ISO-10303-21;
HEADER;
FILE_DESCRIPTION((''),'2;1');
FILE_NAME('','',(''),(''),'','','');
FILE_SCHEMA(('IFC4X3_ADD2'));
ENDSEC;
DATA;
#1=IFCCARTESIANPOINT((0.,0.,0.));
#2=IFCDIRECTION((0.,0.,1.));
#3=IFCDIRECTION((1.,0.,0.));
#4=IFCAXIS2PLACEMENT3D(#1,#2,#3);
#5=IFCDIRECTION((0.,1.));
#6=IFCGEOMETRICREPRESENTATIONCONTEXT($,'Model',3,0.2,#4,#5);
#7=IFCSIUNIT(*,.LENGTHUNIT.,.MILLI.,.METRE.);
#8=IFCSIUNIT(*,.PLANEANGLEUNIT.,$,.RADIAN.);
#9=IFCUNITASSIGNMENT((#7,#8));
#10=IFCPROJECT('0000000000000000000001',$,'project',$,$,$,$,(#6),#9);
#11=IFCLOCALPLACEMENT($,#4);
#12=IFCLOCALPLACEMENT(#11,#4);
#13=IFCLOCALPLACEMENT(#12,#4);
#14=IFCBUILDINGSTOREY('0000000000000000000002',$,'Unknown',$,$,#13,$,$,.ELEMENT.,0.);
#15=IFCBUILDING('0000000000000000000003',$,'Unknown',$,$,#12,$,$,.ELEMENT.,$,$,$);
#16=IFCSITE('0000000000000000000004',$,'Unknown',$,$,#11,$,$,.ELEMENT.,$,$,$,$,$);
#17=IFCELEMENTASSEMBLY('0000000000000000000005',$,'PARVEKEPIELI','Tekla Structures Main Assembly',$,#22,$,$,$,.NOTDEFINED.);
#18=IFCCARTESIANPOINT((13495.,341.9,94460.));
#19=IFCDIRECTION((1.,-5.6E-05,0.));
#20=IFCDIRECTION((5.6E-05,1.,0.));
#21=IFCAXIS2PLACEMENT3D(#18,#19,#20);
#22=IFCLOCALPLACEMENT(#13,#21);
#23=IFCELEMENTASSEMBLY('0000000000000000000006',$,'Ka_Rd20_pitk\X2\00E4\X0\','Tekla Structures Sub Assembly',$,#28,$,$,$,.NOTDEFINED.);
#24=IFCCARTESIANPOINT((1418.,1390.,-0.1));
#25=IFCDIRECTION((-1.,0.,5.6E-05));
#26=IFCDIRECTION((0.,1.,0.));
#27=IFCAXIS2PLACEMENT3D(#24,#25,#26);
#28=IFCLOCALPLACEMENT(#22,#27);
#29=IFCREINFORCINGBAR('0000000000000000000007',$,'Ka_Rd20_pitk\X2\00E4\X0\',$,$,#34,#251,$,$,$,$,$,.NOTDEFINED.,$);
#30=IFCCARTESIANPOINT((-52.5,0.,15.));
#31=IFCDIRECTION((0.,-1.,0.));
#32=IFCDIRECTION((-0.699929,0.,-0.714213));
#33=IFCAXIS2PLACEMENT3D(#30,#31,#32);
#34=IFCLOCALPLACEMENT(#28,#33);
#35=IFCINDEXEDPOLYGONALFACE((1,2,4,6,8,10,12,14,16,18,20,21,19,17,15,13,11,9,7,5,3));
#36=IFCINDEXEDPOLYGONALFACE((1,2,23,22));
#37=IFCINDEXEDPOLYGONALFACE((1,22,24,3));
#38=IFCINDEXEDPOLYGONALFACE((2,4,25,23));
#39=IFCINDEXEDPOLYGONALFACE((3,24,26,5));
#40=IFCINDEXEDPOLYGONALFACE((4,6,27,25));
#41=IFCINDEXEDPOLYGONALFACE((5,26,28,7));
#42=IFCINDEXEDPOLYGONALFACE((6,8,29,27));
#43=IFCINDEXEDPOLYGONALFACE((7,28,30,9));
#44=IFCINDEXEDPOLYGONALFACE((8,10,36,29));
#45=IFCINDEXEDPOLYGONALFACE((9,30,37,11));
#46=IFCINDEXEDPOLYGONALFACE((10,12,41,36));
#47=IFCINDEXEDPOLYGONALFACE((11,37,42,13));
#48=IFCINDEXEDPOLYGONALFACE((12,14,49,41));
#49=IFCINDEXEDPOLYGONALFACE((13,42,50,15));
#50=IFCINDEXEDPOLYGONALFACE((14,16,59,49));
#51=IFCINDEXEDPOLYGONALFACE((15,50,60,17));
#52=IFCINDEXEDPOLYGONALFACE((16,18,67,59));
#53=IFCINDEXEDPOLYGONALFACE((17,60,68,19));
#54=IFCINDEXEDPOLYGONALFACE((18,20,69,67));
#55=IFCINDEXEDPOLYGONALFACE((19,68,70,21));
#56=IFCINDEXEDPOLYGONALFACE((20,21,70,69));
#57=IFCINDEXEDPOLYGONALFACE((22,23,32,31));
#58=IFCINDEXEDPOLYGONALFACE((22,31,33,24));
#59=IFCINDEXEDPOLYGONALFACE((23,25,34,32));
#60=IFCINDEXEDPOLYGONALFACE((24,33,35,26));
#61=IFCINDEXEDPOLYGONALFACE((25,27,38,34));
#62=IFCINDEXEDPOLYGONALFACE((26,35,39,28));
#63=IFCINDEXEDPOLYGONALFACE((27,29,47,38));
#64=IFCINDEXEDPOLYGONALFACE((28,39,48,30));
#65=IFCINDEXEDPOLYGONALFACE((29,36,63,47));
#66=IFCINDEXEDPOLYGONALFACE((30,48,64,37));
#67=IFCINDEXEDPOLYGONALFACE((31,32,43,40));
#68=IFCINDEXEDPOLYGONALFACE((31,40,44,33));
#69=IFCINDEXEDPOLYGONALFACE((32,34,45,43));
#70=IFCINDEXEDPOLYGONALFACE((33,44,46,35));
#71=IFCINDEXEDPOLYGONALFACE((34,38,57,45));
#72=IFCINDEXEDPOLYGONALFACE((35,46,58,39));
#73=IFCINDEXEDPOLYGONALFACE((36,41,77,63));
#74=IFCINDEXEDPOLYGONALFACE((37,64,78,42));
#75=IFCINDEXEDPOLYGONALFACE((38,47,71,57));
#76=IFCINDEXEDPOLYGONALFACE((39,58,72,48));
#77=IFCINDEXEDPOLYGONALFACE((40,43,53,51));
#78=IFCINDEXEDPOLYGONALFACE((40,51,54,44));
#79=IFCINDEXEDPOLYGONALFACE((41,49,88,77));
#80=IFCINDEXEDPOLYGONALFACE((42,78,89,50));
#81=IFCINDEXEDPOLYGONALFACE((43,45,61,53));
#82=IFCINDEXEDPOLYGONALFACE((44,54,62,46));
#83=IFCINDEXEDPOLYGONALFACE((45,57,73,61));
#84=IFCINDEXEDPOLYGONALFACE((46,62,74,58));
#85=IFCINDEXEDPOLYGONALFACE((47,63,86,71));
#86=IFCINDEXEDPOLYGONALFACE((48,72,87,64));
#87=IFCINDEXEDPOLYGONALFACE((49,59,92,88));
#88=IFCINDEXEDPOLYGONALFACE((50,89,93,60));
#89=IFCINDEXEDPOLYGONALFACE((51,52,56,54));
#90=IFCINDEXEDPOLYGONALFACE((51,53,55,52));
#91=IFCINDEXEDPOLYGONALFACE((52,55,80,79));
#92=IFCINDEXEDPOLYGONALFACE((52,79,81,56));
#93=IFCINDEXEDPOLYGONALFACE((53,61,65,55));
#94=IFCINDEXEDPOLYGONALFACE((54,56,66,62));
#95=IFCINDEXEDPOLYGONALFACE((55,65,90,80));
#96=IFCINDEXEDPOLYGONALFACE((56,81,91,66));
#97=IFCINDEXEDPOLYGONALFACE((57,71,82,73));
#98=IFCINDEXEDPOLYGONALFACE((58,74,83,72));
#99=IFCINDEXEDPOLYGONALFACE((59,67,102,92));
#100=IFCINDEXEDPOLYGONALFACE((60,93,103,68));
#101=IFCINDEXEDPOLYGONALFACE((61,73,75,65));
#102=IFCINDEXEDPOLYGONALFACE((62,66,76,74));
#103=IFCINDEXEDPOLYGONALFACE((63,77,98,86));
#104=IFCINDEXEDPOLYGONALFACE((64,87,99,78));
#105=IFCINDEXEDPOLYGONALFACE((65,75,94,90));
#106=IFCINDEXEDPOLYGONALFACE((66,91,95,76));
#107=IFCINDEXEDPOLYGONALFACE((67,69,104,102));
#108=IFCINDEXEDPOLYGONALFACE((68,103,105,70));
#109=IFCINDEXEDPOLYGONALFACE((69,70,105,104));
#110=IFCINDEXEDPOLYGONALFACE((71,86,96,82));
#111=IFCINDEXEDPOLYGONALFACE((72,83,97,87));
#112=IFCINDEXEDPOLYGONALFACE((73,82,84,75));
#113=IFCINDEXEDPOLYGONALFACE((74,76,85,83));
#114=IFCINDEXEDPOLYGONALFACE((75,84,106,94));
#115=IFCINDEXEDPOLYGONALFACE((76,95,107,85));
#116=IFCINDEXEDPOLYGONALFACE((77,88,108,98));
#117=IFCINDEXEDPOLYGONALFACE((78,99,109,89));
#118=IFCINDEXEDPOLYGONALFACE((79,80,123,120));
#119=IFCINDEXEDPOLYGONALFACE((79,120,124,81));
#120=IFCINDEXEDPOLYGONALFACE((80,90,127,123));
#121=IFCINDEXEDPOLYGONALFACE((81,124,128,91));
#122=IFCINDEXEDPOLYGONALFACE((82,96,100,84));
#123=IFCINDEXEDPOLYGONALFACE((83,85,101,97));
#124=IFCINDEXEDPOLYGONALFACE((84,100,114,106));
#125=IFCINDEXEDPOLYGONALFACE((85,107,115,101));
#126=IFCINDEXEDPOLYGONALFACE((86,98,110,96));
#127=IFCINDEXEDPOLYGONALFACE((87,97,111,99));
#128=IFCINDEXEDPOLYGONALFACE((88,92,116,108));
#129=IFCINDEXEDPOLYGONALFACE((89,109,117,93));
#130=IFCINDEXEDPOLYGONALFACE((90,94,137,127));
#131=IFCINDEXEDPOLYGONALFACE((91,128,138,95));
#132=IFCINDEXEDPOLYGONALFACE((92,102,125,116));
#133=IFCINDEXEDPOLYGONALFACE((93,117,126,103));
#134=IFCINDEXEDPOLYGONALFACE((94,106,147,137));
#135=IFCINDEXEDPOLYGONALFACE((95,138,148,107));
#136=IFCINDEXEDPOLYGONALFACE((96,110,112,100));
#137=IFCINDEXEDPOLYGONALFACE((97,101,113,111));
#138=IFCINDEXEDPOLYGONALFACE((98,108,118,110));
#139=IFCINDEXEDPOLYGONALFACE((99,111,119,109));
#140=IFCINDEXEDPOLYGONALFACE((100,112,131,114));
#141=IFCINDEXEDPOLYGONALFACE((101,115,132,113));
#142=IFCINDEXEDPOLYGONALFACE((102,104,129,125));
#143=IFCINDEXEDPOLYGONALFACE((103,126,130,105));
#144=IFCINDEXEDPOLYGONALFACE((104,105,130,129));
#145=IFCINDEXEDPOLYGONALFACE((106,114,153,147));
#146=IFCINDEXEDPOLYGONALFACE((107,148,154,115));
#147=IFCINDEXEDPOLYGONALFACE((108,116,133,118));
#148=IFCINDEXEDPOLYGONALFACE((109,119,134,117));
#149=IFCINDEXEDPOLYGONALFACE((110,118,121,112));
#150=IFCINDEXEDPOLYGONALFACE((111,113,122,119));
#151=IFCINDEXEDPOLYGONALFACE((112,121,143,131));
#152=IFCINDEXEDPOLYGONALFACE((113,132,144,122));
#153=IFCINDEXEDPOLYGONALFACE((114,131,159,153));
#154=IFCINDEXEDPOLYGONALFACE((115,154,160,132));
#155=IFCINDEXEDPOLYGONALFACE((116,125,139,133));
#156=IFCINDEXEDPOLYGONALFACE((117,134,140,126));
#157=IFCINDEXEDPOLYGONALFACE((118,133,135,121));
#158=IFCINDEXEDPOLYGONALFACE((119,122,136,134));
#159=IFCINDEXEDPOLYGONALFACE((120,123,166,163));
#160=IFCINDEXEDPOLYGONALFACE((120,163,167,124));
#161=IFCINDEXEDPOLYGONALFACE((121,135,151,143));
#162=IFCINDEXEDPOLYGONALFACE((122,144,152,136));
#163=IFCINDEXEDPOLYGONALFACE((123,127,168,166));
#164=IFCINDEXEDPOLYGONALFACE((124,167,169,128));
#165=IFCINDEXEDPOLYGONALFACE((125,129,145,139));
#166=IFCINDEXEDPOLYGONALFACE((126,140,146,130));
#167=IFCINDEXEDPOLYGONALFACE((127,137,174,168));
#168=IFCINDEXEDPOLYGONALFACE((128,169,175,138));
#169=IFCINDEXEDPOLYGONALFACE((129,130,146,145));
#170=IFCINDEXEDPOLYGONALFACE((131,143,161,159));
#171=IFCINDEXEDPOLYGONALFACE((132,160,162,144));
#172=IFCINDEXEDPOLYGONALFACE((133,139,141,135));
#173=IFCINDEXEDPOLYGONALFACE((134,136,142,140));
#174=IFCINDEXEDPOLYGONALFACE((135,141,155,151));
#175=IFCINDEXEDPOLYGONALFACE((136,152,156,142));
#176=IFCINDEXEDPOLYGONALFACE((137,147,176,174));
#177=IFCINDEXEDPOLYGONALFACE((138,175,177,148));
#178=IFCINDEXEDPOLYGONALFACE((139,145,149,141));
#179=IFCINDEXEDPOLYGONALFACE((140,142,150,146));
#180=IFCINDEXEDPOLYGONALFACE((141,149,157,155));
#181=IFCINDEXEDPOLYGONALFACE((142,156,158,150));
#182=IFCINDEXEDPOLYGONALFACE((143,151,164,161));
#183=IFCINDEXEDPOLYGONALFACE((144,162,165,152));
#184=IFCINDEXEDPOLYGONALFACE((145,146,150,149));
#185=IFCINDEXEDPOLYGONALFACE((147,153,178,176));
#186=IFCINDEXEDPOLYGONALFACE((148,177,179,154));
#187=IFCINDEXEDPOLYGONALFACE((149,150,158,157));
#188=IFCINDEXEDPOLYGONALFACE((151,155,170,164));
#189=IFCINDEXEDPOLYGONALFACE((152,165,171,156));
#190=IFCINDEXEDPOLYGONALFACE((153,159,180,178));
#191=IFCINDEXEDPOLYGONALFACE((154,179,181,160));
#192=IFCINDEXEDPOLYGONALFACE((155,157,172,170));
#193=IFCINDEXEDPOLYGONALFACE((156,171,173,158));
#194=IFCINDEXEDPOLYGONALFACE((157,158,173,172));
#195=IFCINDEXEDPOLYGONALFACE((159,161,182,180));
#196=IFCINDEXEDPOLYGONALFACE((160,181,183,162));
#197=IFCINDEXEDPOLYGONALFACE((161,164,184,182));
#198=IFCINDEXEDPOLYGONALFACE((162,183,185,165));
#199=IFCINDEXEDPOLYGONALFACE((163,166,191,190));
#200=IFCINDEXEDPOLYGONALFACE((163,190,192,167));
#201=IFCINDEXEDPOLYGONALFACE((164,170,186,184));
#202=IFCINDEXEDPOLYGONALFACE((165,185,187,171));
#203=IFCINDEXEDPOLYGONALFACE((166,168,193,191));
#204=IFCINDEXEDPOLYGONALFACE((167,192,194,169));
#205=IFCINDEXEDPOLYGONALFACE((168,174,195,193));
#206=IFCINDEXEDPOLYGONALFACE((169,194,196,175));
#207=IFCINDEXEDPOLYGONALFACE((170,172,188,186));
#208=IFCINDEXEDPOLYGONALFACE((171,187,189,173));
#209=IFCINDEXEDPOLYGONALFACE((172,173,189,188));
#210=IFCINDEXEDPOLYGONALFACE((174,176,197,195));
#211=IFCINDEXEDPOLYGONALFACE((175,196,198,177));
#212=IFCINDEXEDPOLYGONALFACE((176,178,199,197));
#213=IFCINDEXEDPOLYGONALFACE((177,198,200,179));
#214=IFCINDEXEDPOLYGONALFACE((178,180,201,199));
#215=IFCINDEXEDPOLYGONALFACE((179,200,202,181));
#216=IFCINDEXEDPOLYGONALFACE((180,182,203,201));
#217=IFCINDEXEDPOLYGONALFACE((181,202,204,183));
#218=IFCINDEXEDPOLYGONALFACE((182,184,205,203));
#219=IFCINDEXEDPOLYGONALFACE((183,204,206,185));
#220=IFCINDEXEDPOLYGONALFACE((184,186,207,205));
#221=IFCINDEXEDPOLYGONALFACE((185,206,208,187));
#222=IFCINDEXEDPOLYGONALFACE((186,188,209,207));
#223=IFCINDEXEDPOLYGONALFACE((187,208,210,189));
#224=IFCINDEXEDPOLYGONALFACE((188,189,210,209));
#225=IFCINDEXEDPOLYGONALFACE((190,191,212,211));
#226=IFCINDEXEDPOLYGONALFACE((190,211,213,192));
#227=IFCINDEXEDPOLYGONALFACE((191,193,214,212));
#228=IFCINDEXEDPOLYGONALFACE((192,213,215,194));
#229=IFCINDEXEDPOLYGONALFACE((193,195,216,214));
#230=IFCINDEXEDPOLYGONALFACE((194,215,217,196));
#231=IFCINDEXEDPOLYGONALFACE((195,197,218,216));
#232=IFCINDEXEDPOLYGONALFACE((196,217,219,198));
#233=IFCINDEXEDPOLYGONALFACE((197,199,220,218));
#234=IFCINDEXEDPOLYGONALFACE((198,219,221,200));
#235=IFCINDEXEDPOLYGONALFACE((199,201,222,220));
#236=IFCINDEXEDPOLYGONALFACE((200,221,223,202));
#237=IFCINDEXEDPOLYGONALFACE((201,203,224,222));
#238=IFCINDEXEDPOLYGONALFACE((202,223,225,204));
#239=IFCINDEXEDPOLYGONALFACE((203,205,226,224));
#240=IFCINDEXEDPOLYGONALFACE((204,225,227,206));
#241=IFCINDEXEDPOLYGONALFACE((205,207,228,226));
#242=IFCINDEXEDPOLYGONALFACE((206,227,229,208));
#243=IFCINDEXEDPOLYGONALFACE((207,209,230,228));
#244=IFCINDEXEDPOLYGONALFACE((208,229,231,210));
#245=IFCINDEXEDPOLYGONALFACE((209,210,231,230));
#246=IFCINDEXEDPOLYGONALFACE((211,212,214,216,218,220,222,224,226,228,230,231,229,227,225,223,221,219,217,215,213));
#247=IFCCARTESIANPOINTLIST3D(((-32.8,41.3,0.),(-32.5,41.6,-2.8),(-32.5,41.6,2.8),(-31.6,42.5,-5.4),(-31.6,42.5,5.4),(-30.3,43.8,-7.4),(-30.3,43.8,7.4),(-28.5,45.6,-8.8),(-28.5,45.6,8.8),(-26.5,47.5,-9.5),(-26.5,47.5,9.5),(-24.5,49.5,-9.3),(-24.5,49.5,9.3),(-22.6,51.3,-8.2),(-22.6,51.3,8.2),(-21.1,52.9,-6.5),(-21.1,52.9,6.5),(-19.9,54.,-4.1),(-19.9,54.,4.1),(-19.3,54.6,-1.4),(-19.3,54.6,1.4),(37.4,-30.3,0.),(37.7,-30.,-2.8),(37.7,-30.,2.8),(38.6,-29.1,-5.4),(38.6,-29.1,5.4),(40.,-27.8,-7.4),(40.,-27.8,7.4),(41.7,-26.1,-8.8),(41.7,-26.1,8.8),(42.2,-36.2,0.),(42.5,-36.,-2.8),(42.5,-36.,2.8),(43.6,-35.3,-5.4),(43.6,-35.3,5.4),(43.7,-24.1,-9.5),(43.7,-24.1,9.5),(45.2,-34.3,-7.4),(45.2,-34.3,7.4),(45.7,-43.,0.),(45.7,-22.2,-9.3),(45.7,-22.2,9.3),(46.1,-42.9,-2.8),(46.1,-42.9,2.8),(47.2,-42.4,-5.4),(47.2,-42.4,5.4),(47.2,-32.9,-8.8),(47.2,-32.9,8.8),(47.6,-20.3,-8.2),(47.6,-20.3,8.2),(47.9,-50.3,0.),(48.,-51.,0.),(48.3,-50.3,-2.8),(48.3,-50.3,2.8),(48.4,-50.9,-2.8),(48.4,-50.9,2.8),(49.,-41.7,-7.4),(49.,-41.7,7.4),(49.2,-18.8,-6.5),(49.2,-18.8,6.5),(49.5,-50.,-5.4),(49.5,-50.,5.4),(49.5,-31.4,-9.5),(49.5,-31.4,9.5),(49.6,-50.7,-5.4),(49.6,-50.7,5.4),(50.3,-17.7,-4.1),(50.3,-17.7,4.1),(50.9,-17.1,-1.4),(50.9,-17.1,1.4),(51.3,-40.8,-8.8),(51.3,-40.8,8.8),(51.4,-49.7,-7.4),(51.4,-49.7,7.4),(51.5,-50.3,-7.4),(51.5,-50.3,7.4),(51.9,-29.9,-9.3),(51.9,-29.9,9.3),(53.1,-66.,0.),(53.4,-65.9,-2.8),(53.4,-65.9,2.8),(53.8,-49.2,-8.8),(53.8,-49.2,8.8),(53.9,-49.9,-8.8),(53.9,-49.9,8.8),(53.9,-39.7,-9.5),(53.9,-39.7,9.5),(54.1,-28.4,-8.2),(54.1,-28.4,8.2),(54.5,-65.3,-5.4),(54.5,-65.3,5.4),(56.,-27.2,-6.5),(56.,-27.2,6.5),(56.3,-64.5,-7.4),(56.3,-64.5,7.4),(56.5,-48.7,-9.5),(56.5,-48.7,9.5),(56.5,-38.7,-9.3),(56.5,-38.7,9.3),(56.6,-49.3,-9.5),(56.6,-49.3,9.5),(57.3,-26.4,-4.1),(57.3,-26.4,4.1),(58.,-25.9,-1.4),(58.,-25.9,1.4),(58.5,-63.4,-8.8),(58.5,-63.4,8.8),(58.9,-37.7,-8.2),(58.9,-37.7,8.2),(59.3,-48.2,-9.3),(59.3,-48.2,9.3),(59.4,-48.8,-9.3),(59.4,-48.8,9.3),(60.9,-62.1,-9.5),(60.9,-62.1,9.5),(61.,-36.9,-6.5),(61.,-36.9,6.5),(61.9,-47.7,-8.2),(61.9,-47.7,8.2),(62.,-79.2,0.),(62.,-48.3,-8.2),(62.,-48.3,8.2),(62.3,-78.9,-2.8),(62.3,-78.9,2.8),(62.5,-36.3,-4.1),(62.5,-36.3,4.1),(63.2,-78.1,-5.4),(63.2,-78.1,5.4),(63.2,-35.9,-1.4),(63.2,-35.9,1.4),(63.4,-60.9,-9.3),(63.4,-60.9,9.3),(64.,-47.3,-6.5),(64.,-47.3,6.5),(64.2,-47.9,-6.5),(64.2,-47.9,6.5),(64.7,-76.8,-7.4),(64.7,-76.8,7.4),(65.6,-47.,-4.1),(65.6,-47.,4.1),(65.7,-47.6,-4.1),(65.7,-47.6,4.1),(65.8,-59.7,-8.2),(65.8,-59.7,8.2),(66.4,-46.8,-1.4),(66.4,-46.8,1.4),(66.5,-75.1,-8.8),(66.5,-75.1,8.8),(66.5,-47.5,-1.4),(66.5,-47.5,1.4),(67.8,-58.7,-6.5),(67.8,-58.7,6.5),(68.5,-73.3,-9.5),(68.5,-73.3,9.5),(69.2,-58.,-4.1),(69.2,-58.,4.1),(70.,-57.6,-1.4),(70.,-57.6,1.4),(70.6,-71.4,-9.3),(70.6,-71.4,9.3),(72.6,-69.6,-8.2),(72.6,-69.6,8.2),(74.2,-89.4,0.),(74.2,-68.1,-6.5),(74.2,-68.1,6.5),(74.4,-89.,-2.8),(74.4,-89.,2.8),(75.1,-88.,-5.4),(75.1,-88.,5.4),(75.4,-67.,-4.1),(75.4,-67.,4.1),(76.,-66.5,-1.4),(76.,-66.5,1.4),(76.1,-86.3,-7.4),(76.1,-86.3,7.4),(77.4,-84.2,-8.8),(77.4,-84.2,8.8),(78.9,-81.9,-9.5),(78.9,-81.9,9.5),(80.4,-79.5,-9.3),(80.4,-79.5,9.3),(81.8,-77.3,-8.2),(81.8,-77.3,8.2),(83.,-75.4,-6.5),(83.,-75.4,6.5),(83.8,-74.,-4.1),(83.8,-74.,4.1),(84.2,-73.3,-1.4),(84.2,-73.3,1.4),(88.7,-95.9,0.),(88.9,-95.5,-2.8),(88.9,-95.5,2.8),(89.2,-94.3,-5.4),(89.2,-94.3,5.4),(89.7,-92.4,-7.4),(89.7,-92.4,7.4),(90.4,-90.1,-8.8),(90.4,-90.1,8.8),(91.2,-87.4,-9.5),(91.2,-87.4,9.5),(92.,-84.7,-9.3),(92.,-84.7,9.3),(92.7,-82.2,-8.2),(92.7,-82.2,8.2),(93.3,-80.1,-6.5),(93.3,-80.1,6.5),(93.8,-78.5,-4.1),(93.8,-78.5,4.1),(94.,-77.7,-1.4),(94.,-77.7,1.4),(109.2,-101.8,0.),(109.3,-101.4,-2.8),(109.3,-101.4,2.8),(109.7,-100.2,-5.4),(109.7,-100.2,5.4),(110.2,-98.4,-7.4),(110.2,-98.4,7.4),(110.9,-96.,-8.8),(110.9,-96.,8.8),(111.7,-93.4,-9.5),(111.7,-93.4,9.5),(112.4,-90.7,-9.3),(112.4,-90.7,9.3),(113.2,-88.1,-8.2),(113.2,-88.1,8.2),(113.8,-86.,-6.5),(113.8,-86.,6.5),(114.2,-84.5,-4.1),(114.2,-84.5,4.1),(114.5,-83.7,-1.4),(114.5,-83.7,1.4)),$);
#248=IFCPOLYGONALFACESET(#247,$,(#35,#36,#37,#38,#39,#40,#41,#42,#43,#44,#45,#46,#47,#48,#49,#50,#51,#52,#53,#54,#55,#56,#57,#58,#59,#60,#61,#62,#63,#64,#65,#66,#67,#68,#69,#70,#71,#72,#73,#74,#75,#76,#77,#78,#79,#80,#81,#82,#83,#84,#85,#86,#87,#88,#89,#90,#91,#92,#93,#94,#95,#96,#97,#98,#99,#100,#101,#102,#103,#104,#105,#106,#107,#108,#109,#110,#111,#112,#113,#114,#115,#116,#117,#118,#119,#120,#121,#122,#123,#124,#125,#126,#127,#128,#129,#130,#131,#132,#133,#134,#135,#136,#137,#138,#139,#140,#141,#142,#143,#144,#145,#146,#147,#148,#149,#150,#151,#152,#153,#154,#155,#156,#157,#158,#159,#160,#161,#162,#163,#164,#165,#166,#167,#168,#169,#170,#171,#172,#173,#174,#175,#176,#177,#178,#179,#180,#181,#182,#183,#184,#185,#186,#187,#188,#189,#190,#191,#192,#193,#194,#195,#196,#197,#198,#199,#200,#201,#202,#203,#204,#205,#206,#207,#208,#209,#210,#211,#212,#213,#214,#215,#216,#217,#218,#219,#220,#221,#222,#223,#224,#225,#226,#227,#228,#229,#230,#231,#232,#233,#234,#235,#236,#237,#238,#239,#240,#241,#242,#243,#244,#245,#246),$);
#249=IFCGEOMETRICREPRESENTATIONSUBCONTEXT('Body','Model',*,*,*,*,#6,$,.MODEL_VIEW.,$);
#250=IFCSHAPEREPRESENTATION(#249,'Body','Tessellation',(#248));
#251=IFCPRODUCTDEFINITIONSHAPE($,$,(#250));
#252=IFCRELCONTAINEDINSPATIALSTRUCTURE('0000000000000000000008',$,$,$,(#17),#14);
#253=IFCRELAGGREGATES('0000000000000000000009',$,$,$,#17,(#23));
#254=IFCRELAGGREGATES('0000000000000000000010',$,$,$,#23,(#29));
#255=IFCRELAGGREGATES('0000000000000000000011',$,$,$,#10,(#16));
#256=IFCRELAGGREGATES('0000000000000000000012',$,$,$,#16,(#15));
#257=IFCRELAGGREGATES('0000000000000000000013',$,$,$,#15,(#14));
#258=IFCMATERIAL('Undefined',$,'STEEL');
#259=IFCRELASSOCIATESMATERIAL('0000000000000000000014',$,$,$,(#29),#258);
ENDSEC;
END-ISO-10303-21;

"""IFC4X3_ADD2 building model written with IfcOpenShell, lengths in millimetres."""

from ifc_helpers import new_model, entity, si_unit, direction, frame, origin_with_axes, place, context, subcontext, project, spatial, material, element, aggregate, save


model = new_model("IFC4X3_ADD2")

# Units and contexts
model_context = context("Model", 3, precision=0.2, world=origin_with_axes(), true_north=direction((0.0, 1.0)))
body_context = subcontext(model_context, "Body", "Model", "MODEL_VIEW")
ifc_project = project(units=[si_unit("LENGTHUNIT", "METRE", prefix="MILLI"), si_unit("PLANEANGLEUNIT", "RADIAN")], contexts=[model_context])

# Site, building, storey
site_placement = place(None, origin_with_axes())
site = spatial("IfcSite", under=ifc_project, at=site_placement, Name="Unknown", CompositionType="ELEMENT")
building_placement = place(site_placement, origin_with_axes())
building = spatial("IfcBuilding", under=site, at=building_placement, Name="Unknown", CompositionType="ELEMENT")
storey_placement = place(building_placement, origin_with_axes())
storey = spatial("IfcBuildingStorey", under=building, at=storey_placement, Name="Unknown", CompositionType="ELEMENT", Elevation=0.0)

# Element assemblies
assembly_1_placement = place(storey_placement, frame((13495.0, 341.9, 94460.0), z_axis=(1.0, -0.000056, 0.0), x_axis=(0.000056, 1.0, 0.0)))
assembly_1 = element("IfcElementAssembly", 1, at=assembly_1_placement, inside=storey, Name="PARVEKEPIELI", Description="Tekla Structures Main Assembly", PredefinedType="NOTDEFINED")
assembly_2_placement = place(assembly_1_placement, frame((1418.0, 1390.0, -0.1), z_axis=(-1.0, 0.0, 0.000056), x_axis=(0.0, 1.0, 0.0)))
assembly_2 = element("IfcElementAssembly", 2, at=assembly_2_placement, Name="Ka_Rd20_pitkä", Description="Tekla Structures Sub Assembly", PredefinedType="NOTDEFINED")

aggregate(assembly_1, [assembly_2])

# Reinforcing bar
ifc_material_1 = material(Name="Undefined", Category="STEEL")
reinforcing_bar_1_placement = place(assembly_2_placement, frame((-52.5, 0.0, 15.0), z_axis=(0.0, -1.0, 0.0), x_axis=(-0.699929, 0.0, -0.714213)))
reinforcing_bar_1 = element("IfcReinforcingBar", 3, at=reinforcing_bar_1_placement, material=ifc_material_1, Name="Ka_Rd20_pitkä", PredefinedType="NOTDEFINED", context=body_context, shape_type="AdvancedSweptSolid", body=[
    entity("IfcSweptDiskSolid", entity("IfcIndexedPolyCurve", entity("IfcCartesianPointList3D", [[-26.0, 48.0, 0.0], [44.2, -23.7, 0.0], [52.5, -35.1, 0.0], [57.2, -48.6, 0.0], [57.3, -49.2, 0.0], [69.1, -72.8, 0.0], [91.4, -86.7, 0.0], [111.9, -92.7, 0.0]]), [entity("IfcLineIndex", [1, 2]), entity("IfcArcIndex", [2, 3, 4]), entity("IfcLineIndex", [4, 5]), entity("IfcArcIndex", [5, 6, 7]), entity("IfcLineIndex", [7, 8])]), 9.5),
])
aggregate(assembly_2, [reinforcing_bar_1])

save(model, "model.ifc")
